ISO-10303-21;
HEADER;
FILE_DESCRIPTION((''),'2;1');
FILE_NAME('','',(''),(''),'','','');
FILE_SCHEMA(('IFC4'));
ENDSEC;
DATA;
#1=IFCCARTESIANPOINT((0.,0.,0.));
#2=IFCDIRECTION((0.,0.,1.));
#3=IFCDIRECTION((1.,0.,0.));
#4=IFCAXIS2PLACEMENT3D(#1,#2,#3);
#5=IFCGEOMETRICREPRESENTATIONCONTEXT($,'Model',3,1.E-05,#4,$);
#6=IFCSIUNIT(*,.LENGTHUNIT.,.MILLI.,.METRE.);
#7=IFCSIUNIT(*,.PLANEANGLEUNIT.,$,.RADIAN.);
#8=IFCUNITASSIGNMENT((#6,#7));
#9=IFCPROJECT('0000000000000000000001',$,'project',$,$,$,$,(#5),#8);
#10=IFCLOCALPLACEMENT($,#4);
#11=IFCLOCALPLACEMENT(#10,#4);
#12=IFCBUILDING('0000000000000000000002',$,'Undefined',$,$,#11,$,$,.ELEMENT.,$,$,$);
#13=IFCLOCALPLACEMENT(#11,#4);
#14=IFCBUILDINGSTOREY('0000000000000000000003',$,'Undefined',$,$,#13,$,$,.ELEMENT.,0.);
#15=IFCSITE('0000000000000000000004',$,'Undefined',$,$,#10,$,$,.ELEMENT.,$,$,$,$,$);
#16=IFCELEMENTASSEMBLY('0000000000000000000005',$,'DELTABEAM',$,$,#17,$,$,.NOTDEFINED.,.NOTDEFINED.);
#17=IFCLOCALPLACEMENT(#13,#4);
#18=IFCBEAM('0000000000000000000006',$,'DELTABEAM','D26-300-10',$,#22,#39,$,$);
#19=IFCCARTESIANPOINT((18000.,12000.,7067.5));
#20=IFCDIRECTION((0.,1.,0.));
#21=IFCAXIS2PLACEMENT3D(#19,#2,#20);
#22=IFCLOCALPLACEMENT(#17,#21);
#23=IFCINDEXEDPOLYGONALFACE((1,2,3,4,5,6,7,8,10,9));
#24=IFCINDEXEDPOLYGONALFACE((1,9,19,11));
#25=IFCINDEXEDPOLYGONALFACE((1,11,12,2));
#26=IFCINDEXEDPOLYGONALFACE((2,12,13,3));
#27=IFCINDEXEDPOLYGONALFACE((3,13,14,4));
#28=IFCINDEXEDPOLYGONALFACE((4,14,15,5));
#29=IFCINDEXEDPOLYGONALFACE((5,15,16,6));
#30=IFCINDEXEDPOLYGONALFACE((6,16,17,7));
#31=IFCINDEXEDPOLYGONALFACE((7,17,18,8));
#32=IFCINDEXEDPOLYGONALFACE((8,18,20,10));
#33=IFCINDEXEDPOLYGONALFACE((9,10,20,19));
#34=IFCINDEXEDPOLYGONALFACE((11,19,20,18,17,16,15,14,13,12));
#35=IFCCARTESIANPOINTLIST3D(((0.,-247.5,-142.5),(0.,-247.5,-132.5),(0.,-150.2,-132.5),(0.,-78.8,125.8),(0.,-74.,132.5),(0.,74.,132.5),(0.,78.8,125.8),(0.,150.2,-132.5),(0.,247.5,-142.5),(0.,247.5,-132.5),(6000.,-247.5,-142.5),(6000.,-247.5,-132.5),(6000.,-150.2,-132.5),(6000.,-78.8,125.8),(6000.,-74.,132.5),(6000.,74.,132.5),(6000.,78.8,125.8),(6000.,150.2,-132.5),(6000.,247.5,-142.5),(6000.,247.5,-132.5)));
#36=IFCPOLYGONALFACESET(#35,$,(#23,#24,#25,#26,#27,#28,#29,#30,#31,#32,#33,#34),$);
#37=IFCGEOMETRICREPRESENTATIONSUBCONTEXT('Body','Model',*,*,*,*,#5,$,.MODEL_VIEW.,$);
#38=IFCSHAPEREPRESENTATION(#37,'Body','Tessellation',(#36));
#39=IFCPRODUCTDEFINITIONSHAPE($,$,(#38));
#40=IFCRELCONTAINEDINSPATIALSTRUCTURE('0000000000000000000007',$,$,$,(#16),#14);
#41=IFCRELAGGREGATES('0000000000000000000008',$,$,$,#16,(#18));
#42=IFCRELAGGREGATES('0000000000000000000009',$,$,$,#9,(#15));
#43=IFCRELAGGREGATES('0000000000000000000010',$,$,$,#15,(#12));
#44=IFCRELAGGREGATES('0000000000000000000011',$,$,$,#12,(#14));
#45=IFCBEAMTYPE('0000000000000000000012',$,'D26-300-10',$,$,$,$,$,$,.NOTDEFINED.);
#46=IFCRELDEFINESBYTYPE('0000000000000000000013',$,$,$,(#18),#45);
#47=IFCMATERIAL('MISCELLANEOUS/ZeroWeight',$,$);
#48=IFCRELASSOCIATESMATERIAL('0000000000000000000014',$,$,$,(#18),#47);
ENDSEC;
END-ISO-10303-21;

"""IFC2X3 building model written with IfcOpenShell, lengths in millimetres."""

from ifc_helpers import new_model, si_unit, frame, origin_with_axes, place, context, subcontext, project, spatial, polyline, outline, extrude, material, type_object, element, aggregate, save


model = new_model("IFC2X3")

# Units and contexts
model_context = context("Model", 3, precision=1e-05, world=origin_with_axes())
body_context = subcontext(model_context, "Body", "Model", "MODEL_VIEW")
ifc_project = project(units=[si_unit("LENGTHUNIT", "METRE", prefix="MILLI"), si_unit("PLANEANGLEUNIT", "RADIAN")], contexts=[model_context])

# Site, building, storey
site_placement = place(None, origin_with_axes())
site = spatial("IfcSite", under=ifc_project, at=site_placement, Name="Undefined", CompositionType="ELEMENT")
building_placement = place(site_placement, origin_with_axes())
building = spatial("IfcBuilding", under=site, at=building_placement, Name="Undefined", CompositionType="ELEMENT")
storey_placement = place(building_placement, origin_with_axes())
storey = spatial("IfcBuildingStorey", under=building, at=storey_placement, Name="Undefined", CompositionType="ELEMENT", Elevation=0.0)

# Element assembly, beam
assembly_1_placement = place(storey_placement, origin_with_axes())
assembly_1 = element("IfcElementAssembly", 1, at=assembly_1_placement, inside=storey, Name="DELTABEAM", AssemblyPlace="NOTDEFINED", PredefinedType="NOTDEFINED")
ifc_material_1 = material(Name="MISCELLANEOUS/ZeroWeight")
beam_type = type_object("IfcBeamType", Name="D26-300-10", PredefinedType="NOTDEFINED")
beam_placement = place(assembly_1_placement, frame((18000.0, 12000.0, 7067.5), z_axis=(0.0, 0.0, 1.0), x_axis=(0.0, 1.0, 0.0)))
beam = element("IfcBeam", 2, at=beam_placement, type_object=beam_type, material=ifc_material_1, Name="DELTABEAM", Description="D26-300-10", context=body_context, shape_type="SweptSolid", body=[
    extrude(outline(polyline([(-75.1, 120.5), (-145.0, -132.5), (247.5, -132.5), (247.5, -142.5), (-247.5, -142.5), (-247.5, -132.5), (-150.2, -132.5), (-78.8, 125.8), (-74.0, 132.5), (74.0, 132.5), (78.8, 125.8), (150.2, -132.5), (145.0, -132.5), (75.1, 120.5), (-75.1, 120.5)])), frame((6000.0, 0.0, 0.0), z_axis=(-1.0, 0.0, 0.0), x_axis=(0.0, -1.0, 0.0)), (0.0, 0.0, 1.0), 6000.0),
])
aggregate(assembly_1, [beam])

save(model, "model.ifc")
